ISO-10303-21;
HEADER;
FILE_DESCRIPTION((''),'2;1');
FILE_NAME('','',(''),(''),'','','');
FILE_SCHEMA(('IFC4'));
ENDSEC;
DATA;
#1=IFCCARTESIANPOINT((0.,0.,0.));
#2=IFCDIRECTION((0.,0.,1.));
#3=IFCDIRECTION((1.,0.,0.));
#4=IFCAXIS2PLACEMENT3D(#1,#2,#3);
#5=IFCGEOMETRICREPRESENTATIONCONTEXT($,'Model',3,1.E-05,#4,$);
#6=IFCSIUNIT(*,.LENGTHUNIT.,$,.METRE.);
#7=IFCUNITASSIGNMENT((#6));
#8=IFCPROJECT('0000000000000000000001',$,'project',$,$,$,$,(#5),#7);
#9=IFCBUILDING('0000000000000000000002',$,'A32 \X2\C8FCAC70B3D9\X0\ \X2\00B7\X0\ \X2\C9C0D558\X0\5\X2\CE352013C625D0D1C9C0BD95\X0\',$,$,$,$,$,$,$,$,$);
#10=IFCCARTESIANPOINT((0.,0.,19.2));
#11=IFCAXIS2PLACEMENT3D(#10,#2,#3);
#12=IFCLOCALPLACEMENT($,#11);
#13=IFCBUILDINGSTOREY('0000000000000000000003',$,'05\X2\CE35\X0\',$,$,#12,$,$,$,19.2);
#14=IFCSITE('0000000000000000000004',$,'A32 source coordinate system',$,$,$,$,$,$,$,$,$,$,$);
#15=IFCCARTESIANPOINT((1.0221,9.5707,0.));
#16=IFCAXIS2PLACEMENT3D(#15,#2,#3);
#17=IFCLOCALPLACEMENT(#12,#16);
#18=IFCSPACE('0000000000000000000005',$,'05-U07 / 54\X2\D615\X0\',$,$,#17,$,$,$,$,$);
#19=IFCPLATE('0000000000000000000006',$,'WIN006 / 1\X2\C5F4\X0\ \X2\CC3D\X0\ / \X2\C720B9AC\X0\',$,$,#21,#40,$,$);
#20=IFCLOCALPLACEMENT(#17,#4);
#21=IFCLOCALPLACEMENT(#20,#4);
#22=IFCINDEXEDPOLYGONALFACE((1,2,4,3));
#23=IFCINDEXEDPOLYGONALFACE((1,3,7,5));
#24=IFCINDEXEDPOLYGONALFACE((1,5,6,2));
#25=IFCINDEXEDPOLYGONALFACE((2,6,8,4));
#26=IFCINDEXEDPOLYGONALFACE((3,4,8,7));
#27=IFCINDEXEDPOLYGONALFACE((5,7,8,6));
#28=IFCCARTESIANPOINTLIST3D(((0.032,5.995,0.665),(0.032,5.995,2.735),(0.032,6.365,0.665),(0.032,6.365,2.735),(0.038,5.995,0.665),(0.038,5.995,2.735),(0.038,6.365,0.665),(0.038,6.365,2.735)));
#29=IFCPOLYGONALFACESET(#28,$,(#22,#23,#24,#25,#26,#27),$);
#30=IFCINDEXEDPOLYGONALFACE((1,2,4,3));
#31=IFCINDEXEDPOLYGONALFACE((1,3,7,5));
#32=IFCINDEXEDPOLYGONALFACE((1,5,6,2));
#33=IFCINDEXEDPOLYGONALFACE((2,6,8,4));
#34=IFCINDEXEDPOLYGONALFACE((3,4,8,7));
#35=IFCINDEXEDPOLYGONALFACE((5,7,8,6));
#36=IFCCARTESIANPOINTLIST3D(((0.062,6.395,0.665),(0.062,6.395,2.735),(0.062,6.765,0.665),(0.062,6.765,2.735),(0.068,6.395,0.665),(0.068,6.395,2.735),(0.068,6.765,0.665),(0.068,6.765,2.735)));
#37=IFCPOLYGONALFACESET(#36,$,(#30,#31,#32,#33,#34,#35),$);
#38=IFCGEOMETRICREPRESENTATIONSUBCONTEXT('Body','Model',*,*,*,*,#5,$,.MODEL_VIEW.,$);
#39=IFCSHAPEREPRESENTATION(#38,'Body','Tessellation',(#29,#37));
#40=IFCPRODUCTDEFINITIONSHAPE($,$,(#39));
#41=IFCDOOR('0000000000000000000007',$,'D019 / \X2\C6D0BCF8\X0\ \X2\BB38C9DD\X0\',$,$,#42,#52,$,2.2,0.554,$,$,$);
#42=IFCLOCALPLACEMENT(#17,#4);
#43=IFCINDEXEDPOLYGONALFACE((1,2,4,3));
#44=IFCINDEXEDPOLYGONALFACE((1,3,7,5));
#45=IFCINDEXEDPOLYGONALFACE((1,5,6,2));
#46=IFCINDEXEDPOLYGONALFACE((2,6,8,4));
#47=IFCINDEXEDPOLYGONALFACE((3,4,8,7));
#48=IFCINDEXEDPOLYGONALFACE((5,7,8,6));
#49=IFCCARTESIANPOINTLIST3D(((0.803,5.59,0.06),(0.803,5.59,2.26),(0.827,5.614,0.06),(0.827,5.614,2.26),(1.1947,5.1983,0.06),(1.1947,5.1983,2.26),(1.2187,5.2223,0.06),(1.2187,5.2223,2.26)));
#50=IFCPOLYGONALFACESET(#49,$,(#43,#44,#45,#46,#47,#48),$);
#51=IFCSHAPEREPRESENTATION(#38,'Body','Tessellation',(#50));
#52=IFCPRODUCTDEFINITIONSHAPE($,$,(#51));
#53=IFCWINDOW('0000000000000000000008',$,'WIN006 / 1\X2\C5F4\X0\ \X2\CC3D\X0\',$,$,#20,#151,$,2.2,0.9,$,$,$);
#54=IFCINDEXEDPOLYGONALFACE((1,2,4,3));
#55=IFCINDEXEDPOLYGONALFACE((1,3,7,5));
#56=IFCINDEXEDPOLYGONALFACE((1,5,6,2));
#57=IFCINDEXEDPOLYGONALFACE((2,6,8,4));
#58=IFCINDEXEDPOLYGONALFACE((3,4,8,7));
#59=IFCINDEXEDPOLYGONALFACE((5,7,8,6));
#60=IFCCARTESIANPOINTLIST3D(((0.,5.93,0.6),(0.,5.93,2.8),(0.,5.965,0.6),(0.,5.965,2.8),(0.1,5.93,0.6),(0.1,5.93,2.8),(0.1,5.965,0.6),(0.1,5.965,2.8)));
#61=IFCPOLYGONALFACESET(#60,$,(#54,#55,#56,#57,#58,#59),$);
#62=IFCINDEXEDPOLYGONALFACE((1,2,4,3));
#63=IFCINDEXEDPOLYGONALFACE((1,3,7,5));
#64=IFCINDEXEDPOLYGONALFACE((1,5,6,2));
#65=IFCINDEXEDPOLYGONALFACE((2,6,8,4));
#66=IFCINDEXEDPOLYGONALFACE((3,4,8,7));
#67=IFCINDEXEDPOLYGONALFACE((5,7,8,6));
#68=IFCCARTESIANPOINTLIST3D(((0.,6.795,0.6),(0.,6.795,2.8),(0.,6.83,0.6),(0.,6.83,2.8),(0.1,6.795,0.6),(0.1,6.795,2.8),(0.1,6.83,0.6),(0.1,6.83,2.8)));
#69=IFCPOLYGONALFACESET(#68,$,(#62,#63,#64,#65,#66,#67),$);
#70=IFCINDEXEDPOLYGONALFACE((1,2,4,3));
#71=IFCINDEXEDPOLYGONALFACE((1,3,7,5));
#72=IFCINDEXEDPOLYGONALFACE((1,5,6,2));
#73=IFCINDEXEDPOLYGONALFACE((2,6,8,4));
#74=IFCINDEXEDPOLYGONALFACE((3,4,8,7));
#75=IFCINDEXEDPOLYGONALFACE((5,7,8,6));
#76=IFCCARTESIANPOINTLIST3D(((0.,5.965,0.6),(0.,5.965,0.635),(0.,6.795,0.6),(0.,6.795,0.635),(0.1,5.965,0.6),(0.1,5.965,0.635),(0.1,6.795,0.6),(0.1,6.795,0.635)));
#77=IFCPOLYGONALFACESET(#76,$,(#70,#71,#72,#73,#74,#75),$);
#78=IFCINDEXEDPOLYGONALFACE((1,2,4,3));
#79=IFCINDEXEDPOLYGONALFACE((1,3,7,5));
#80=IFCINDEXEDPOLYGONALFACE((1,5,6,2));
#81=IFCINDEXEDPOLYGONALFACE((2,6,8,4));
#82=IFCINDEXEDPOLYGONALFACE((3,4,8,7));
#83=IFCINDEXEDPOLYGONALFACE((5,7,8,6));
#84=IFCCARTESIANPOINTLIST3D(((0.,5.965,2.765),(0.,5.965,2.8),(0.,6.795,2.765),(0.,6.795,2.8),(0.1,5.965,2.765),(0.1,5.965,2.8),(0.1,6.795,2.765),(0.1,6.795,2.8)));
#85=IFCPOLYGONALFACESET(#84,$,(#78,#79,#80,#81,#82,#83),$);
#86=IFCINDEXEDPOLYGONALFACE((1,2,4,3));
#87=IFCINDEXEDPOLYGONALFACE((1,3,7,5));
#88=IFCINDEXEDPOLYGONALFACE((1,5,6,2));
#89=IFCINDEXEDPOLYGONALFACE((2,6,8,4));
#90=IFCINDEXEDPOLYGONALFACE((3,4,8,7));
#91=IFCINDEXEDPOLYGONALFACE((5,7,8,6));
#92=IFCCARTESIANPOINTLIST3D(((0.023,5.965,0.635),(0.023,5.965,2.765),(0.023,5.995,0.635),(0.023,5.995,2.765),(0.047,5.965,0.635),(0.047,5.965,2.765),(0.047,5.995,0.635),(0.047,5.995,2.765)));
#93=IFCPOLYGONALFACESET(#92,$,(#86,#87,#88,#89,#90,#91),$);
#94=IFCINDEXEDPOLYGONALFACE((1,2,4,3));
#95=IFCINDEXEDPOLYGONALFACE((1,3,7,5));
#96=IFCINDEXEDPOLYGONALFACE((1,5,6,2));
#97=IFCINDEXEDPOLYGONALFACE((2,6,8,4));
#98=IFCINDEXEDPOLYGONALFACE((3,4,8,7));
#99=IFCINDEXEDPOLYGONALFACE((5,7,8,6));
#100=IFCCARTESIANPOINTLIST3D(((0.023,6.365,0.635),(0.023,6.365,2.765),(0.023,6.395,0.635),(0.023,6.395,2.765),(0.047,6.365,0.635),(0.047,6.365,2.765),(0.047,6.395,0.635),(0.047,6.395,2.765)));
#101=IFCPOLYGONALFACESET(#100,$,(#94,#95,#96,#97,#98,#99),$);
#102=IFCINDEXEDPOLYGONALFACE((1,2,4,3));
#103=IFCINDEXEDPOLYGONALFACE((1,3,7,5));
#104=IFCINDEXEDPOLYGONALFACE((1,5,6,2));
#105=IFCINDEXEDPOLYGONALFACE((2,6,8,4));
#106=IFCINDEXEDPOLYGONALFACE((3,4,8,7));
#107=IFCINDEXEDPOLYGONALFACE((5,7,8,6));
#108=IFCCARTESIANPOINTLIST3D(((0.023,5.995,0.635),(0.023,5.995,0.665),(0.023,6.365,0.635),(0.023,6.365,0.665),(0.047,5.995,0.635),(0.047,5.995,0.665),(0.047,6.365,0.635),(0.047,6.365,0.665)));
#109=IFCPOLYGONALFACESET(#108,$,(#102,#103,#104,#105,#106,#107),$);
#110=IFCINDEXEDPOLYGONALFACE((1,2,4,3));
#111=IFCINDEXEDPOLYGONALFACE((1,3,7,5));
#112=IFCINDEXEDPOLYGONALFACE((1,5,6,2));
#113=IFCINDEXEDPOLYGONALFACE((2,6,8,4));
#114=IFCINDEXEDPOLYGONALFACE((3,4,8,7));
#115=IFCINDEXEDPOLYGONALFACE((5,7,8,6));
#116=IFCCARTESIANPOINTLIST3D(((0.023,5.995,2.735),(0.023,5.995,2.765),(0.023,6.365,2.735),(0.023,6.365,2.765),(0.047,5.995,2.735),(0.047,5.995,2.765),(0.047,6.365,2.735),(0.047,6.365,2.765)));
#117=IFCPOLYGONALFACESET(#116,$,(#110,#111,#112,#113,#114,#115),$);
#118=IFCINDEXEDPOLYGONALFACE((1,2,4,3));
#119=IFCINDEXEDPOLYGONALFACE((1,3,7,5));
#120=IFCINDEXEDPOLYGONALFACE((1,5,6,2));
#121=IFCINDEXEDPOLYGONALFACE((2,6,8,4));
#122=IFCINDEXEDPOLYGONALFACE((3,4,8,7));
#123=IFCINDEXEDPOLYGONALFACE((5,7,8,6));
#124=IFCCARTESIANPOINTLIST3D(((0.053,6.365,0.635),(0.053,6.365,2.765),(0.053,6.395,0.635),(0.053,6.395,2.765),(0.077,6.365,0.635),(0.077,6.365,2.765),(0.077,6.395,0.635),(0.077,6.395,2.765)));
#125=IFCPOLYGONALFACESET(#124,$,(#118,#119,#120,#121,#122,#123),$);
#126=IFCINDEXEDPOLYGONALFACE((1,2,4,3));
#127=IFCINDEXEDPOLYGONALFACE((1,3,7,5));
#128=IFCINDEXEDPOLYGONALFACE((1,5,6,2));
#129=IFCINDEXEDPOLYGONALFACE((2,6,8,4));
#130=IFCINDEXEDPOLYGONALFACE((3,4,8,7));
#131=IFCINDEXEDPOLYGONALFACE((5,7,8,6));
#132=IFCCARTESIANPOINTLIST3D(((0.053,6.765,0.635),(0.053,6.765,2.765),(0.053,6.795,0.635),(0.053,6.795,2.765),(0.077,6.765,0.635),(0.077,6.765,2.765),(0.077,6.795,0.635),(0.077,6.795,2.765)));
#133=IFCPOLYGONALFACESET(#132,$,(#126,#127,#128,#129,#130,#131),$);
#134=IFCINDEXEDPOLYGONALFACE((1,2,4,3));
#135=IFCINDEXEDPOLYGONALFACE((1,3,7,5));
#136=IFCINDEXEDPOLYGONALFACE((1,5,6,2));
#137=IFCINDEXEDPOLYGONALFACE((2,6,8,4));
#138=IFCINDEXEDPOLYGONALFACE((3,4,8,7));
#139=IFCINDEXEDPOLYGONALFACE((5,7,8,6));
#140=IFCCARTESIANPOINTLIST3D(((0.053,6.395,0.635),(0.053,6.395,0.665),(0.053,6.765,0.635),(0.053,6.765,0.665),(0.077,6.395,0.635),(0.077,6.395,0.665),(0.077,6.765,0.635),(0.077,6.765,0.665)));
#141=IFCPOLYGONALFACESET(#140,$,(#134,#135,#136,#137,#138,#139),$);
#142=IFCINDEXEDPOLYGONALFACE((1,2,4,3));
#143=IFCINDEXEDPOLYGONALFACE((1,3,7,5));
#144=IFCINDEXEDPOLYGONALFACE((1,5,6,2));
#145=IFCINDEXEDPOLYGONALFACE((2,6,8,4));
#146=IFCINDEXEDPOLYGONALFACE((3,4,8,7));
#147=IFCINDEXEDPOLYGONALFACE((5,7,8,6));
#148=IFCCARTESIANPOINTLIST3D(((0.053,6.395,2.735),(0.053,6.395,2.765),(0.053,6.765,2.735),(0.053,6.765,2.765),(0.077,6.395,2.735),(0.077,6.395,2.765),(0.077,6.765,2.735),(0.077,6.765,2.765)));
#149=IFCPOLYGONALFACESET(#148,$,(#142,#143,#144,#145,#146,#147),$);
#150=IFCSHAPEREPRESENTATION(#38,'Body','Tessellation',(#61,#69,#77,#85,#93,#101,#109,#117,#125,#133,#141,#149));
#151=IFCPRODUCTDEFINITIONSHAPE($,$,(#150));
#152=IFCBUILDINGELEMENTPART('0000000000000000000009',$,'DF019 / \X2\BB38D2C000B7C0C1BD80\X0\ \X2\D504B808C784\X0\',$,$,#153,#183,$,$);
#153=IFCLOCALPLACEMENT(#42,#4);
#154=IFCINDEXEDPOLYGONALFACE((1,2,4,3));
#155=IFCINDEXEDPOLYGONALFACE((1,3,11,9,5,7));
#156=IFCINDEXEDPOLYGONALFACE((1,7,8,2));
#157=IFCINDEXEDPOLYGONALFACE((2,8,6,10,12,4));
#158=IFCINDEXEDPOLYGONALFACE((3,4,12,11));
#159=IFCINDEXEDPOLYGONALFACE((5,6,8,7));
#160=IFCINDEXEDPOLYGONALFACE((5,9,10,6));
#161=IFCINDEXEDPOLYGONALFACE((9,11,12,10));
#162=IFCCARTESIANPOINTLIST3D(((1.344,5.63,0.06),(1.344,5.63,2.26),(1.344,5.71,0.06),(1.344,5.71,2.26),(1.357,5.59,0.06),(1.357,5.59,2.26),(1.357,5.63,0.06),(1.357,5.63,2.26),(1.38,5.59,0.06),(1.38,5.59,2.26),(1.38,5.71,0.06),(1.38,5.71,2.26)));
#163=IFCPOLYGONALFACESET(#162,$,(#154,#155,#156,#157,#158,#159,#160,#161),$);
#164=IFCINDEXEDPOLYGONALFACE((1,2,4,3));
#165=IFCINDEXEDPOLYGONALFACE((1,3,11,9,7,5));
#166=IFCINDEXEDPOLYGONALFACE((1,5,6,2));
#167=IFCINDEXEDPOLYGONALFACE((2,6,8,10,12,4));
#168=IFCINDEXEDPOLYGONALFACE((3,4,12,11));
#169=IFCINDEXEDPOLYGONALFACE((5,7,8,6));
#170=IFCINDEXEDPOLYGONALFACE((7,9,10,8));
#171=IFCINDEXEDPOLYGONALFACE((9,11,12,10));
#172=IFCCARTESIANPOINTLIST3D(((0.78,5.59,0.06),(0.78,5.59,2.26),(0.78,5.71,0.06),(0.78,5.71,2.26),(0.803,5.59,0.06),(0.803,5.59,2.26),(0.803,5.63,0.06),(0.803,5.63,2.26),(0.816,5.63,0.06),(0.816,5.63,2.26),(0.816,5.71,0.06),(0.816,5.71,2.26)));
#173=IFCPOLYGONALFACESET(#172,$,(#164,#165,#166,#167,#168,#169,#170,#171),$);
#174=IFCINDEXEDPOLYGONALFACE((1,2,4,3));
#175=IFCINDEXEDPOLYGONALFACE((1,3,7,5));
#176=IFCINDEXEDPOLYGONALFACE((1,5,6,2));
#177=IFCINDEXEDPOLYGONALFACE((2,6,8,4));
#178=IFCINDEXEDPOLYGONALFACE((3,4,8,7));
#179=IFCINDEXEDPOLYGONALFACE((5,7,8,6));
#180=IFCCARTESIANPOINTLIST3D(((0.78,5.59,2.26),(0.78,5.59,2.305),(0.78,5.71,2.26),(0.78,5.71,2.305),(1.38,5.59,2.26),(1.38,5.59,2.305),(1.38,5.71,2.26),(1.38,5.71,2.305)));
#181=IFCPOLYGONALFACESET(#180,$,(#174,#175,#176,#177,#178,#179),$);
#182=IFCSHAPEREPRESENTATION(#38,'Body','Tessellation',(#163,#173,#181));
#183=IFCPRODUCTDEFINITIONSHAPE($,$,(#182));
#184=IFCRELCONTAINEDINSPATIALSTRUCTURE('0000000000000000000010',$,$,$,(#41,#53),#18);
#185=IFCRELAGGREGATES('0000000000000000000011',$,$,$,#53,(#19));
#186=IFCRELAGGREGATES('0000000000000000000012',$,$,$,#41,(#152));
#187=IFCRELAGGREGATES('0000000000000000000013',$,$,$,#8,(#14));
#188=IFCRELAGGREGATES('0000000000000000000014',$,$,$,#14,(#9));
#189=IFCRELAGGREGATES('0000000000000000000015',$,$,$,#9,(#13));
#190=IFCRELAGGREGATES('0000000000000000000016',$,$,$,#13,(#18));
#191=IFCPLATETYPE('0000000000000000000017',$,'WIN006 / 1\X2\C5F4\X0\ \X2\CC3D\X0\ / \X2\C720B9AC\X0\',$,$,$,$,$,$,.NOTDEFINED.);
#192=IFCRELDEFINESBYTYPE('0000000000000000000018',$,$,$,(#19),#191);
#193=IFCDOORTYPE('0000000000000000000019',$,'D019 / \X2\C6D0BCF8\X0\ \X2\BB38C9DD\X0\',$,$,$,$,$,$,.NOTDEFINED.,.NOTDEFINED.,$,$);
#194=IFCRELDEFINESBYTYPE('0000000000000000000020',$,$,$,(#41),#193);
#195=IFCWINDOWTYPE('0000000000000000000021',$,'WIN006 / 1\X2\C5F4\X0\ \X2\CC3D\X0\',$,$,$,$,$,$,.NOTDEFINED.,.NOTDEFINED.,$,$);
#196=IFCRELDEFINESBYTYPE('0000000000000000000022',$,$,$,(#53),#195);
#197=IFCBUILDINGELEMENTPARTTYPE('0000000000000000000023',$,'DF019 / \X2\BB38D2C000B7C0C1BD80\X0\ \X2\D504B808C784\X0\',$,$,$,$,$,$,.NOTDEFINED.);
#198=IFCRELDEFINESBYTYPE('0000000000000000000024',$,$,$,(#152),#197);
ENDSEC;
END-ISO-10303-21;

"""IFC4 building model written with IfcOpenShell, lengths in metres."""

from ifc_helpers import new_model, si_unit, frame, origin, origin_with_axes, place, context, subcontext, project, spatial, polyline, outline, extrude, source, transform, mapped, type_object, type_shapes, element, aggregate, save


model = new_model("IFC4")

# Units and contexts
model_context = context("Model", 3, precision=1e-05, world=origin_with_axes())
body_context = subcontext(model_context, "Body", "Model", "MODEL_VIEW")
ifc_project = project(units=[si_unit("LENGTHUNIT", "METRE")], contexts=[model_context])

# Plate
storey_placement = place(None, frame((0.0, 0.0, 19.2), z_axis=(0.0, 0.0, 1.0), x_axis=(1.0, 0.0, 0.0)))
space_placement = place(storey_placement, frame((1.0221, 9.5707, 0.0), z_axis=(0.0, 0.0, 1.0), x_axis=(1.0, 0.0, 0.0)))
plate_type_1 = type_object("IfcPlateType", Name="WIN006 / 1열 창 / 유리", PredefinedType="NOTDEFINED")
shared_shape_1 = source(origin(), body_context, "Body", "SweptSolid", [
    extrude(outline(polyline([(0.032, 5.995), (0.032, 6.365), (0.038, 6.365), (0.038, 5.995), (0.032, 5.995)])), frame((0.0, 0.0, 0.665)), (0.0, 0.0, 1.0), 2.07),
    extrude(outline(polyline([(0.062, 6.395), (0.062, 6.765), (0.068, 6.765), (0.068, 6.395), (0.062, 6.395)])), frame((0.0, 0.0, 0.665)), (0.0, 0.0, 1.0), 2.07),
])
type_shapes(plate_type_1, [shared_shape_1])
window_1_placement = place(space_placement, origin_with_axes())
plate_1_placement = place(window_1_placement, origin_with_axes())
plate_1 = element("IfcPlate", 1, at=plate_1_placement, type_object=plate_type_1, Name="WIN006 / 1열 창 / 유리", context=body_context, shape_type="MappedRepresentation", body=[
    mapped(shared_shape_1, transform((0.0, 0.0, 0.0), scale=1.0)),
])

# Site, building, storey, space
site = spatial("IfcSite", under=ifc_project, Name="A32 source coordinate system")
building = spatial("IfcBuilding", under=site, Name="A32 주거동 · 지하5층–옥탑지붕")
storey = spatial("IfcBuildingStorey", under=building, at=storey_placement, Name="05층", Elevation=19.2)
space = spatial("IfcSpace", under=storey, at=space_placement, Name="05-U07 / 54형")

# Door
door_type_1 = type_object("IfcDoorType", Name="D019 / 원본 문짝", OperationType="NOTDEFINED", PredefinedType="NOTDEFINED")
shared_shape_2 = source(origin(), body_context, "Body", "SweptSolid", [
    extrude(outline(polyline([(1.2187, 5.2223), (1.1947, 5.1983), (0.803, 5.59), (0.827, 5.614), (1.2187, 5.2223)])), frame((0.0, 0.0, 0.06)), (0.0, 0.0, 1.0), 2.2),
])
type_shapes(door_type_1, [shared_shape_2])
door_1_placement = place(space_placement, origin_with_axes())
door_1 = element("IfcDoor", 2, at=door_1_placement, inside=space, type_object=door_type_1, Name="D019 / 원본 문짝", OverallHeight=2.2, OverallWidth=0.554, context=body_context, shape_type="MappedRepresentation", body=[
    mapped(shared_shape_2, transform((0.0, 0.0, 0.0), scale=1.0)),
])

# Window
window_type_1 = type_object("IfcWindowType", Name="WIN006 / 1열 창", PartitioningType="NOTDEFINED", PredefinedType="NOTDEFINED")
shared_shape_3 = source(origin(), body_context, "Body", "SweptSolid", [
    extrude(outline(polyline([(0.0, 5.93), (0.0, 5.965), (0.1, 5.965), (0.1, 5.93), (0.0, 5.93)])), frame((0.0, 0.0, 0.6)), (0.0, 0.0, 1.0), 2.2),
    extrude(outline(polyline([(0.0, 6.795), (0.0, 6.83), (0.1, 6.83), (0.1, 6.795), (0.0, 6.795)])), frame((0.0, 0.0, 0.6)), (0.0, 0.0, 1.0), 2.2),
    extrude(outline(polyline([(0.0, 5.965), (0.0, 6.795), (0.1, 6.795), (0.1, 5.965), (0.0, 5.965)])), frame((0.0, 0.0, 0.6)), (0.0, 0.0, 1.0), 0.035),
    extrude(outline(polyline([(0.0, 5.965), (0.0, 6.795), (0.1, 6.795), (0.1, 5.965), (0.0, 5.965)])), frame((0.0, 0.0, 2.765)), (0.0, 0.0, 1.0), 0.035),
    extrude(outline(polyline([(0.023, 5.965), (0.023, 5.995), (0.047, 5.995), (0.047, 5.965), (0.023, 5.965)])), frame((0.0, 0.0, 0.635)), (0.0, 0.0, 1.0), 2.13),
    extrude(outline(polyline([(0.023, 6.365), (0.023, 6.395), (0.047, 6.395), (0.047, 6.365), (0.023, 6.365)])), frame((0.0, 0.0, 0.635)), (0.0, 0.0, 1.0), 2.13),
    extrude(outline(polyline([(0.023, 5.995), (0.023, 6.365), (0.047, 6.365), (0.047, 5.995), (0.023, 5.995)])), frame((0.0, 0.0, 0.635)), (0.0, 0.0, 1.0), 0.03),
    extrude(outline(polyline([(0.023, 5.995), (0.023, 6.365), (0.047, 6.365), (0.047, 5.995), (0.023, 5.995)])), frame((0.0, 0.0, 2.735)), (0.0, 0.0, 1.0), 0.03),
    extrude(outline(polyline([(0.053, 6.365), (0.053, 6.395), (0.077, 6.395), (0.077, 6.365), (0.053, 6.365)])), frame((0.0, 0.0, 0.635)), (0.0, 0.0, 1.0), 2.13),
    extrude(outline(polyline([(0.053, 6.765), (0.053, 6.795), (0.077, 6.795), (0.077, 6.765), (0.053, 6.765)])), frame((0.0, 0.0, 0.635)), (0.0, 0.0, 1.0), 2.13),
    extrude(outline(polyline([(0.053, 6.395), (0.053, 6.765), (0.077, 6.765), (0.077, 6.395), (0.053, 6.395)])), frame((0.0, 0.0, 0.635)), (0.0, 0.0, 1.0), 0.03),
    extrude(outline(polyline([(0.053, 6.395), (0.053, 6.765), (0.077, 6.765), (0.077, 6.395), (0.053, 6.395)])), frame((0.0, 0.0, 2.735)), (0.0, 0.0, 1.0), 0.03),
])
type_shapes(window_type_1, [shared_shape_3])
window_1 = element("IfcWindow", 3, at=window_1_placement, inside=space, type_object=window_type_1, Name="WIN006 / 1열 창", OverallHeight=2.2, OverallWidth=0.9, context=body_context, shape_type="MappedRepresentation", body=[
    mapped(shared_shape_3, transform((0.0, 0.0, 0.0), scale=1.0)),
])
aggregate(window_1, [plate_1])

# Building element part
building_element_part_type_1 = type_object("IfcBuildingElementPartType", Name="DF019 / 문틀·상부 프레임", PredefinedType="NOTDEFINED")
shared_shape_4 = source(origin(), body_context, "Body", "SweptSolid", [
    extrude(outline(polyline([(1.38, 5.59), (1.357, 5.59), (1.357, 5.63), (1.344, 5.63), (1.344, 5.71), (1.38, 5.71), (1.38, 5.59)])), frame((0.0, 0.0, 0.06)), (0.0, 0.0, 1.0), 2.2),
    extrude(outline(polyline([(0.816, 5.71), (0.816, 5.63), (0.803, 5.63), (0.803, 5.59), (0.78, 5.59), (0.78, 5.71), (0.816, 5.71)])), frame((0.0, 0.0, 0.06)), (0.0, 0.0, 1.0), 2.2),
    extrude(outline(polyline([(0.78, 5.59), (0.78, 5.71), (1.38, 5.71), (1.38, 5.59), (0.78, 5.59)])), frame((0.0, 0.0, 2.26)), (0.0, 0.0, 1.0), 0.045),
])
type_shapes(building_element_part_type_1, [shared_shape_4])
building_element_part_1_placement = place(door_1_placement, origin_with_axes())
building_element_part_1 = element("IfcBuildingElementPart", 4, at=building_element_part_1_placement, type_object=building_element_part_type_1, Name="DF019 / 문틀·상부 프레임", context=body_context, shape_type="MappedRepresentation", body=[
    mapped(shared_shape_4, transform((0.0, 0.0, 0.0), scale=1.0)),
])
aggregate(door_1, [building_element_part_1])

save(model, "model.ifc")
